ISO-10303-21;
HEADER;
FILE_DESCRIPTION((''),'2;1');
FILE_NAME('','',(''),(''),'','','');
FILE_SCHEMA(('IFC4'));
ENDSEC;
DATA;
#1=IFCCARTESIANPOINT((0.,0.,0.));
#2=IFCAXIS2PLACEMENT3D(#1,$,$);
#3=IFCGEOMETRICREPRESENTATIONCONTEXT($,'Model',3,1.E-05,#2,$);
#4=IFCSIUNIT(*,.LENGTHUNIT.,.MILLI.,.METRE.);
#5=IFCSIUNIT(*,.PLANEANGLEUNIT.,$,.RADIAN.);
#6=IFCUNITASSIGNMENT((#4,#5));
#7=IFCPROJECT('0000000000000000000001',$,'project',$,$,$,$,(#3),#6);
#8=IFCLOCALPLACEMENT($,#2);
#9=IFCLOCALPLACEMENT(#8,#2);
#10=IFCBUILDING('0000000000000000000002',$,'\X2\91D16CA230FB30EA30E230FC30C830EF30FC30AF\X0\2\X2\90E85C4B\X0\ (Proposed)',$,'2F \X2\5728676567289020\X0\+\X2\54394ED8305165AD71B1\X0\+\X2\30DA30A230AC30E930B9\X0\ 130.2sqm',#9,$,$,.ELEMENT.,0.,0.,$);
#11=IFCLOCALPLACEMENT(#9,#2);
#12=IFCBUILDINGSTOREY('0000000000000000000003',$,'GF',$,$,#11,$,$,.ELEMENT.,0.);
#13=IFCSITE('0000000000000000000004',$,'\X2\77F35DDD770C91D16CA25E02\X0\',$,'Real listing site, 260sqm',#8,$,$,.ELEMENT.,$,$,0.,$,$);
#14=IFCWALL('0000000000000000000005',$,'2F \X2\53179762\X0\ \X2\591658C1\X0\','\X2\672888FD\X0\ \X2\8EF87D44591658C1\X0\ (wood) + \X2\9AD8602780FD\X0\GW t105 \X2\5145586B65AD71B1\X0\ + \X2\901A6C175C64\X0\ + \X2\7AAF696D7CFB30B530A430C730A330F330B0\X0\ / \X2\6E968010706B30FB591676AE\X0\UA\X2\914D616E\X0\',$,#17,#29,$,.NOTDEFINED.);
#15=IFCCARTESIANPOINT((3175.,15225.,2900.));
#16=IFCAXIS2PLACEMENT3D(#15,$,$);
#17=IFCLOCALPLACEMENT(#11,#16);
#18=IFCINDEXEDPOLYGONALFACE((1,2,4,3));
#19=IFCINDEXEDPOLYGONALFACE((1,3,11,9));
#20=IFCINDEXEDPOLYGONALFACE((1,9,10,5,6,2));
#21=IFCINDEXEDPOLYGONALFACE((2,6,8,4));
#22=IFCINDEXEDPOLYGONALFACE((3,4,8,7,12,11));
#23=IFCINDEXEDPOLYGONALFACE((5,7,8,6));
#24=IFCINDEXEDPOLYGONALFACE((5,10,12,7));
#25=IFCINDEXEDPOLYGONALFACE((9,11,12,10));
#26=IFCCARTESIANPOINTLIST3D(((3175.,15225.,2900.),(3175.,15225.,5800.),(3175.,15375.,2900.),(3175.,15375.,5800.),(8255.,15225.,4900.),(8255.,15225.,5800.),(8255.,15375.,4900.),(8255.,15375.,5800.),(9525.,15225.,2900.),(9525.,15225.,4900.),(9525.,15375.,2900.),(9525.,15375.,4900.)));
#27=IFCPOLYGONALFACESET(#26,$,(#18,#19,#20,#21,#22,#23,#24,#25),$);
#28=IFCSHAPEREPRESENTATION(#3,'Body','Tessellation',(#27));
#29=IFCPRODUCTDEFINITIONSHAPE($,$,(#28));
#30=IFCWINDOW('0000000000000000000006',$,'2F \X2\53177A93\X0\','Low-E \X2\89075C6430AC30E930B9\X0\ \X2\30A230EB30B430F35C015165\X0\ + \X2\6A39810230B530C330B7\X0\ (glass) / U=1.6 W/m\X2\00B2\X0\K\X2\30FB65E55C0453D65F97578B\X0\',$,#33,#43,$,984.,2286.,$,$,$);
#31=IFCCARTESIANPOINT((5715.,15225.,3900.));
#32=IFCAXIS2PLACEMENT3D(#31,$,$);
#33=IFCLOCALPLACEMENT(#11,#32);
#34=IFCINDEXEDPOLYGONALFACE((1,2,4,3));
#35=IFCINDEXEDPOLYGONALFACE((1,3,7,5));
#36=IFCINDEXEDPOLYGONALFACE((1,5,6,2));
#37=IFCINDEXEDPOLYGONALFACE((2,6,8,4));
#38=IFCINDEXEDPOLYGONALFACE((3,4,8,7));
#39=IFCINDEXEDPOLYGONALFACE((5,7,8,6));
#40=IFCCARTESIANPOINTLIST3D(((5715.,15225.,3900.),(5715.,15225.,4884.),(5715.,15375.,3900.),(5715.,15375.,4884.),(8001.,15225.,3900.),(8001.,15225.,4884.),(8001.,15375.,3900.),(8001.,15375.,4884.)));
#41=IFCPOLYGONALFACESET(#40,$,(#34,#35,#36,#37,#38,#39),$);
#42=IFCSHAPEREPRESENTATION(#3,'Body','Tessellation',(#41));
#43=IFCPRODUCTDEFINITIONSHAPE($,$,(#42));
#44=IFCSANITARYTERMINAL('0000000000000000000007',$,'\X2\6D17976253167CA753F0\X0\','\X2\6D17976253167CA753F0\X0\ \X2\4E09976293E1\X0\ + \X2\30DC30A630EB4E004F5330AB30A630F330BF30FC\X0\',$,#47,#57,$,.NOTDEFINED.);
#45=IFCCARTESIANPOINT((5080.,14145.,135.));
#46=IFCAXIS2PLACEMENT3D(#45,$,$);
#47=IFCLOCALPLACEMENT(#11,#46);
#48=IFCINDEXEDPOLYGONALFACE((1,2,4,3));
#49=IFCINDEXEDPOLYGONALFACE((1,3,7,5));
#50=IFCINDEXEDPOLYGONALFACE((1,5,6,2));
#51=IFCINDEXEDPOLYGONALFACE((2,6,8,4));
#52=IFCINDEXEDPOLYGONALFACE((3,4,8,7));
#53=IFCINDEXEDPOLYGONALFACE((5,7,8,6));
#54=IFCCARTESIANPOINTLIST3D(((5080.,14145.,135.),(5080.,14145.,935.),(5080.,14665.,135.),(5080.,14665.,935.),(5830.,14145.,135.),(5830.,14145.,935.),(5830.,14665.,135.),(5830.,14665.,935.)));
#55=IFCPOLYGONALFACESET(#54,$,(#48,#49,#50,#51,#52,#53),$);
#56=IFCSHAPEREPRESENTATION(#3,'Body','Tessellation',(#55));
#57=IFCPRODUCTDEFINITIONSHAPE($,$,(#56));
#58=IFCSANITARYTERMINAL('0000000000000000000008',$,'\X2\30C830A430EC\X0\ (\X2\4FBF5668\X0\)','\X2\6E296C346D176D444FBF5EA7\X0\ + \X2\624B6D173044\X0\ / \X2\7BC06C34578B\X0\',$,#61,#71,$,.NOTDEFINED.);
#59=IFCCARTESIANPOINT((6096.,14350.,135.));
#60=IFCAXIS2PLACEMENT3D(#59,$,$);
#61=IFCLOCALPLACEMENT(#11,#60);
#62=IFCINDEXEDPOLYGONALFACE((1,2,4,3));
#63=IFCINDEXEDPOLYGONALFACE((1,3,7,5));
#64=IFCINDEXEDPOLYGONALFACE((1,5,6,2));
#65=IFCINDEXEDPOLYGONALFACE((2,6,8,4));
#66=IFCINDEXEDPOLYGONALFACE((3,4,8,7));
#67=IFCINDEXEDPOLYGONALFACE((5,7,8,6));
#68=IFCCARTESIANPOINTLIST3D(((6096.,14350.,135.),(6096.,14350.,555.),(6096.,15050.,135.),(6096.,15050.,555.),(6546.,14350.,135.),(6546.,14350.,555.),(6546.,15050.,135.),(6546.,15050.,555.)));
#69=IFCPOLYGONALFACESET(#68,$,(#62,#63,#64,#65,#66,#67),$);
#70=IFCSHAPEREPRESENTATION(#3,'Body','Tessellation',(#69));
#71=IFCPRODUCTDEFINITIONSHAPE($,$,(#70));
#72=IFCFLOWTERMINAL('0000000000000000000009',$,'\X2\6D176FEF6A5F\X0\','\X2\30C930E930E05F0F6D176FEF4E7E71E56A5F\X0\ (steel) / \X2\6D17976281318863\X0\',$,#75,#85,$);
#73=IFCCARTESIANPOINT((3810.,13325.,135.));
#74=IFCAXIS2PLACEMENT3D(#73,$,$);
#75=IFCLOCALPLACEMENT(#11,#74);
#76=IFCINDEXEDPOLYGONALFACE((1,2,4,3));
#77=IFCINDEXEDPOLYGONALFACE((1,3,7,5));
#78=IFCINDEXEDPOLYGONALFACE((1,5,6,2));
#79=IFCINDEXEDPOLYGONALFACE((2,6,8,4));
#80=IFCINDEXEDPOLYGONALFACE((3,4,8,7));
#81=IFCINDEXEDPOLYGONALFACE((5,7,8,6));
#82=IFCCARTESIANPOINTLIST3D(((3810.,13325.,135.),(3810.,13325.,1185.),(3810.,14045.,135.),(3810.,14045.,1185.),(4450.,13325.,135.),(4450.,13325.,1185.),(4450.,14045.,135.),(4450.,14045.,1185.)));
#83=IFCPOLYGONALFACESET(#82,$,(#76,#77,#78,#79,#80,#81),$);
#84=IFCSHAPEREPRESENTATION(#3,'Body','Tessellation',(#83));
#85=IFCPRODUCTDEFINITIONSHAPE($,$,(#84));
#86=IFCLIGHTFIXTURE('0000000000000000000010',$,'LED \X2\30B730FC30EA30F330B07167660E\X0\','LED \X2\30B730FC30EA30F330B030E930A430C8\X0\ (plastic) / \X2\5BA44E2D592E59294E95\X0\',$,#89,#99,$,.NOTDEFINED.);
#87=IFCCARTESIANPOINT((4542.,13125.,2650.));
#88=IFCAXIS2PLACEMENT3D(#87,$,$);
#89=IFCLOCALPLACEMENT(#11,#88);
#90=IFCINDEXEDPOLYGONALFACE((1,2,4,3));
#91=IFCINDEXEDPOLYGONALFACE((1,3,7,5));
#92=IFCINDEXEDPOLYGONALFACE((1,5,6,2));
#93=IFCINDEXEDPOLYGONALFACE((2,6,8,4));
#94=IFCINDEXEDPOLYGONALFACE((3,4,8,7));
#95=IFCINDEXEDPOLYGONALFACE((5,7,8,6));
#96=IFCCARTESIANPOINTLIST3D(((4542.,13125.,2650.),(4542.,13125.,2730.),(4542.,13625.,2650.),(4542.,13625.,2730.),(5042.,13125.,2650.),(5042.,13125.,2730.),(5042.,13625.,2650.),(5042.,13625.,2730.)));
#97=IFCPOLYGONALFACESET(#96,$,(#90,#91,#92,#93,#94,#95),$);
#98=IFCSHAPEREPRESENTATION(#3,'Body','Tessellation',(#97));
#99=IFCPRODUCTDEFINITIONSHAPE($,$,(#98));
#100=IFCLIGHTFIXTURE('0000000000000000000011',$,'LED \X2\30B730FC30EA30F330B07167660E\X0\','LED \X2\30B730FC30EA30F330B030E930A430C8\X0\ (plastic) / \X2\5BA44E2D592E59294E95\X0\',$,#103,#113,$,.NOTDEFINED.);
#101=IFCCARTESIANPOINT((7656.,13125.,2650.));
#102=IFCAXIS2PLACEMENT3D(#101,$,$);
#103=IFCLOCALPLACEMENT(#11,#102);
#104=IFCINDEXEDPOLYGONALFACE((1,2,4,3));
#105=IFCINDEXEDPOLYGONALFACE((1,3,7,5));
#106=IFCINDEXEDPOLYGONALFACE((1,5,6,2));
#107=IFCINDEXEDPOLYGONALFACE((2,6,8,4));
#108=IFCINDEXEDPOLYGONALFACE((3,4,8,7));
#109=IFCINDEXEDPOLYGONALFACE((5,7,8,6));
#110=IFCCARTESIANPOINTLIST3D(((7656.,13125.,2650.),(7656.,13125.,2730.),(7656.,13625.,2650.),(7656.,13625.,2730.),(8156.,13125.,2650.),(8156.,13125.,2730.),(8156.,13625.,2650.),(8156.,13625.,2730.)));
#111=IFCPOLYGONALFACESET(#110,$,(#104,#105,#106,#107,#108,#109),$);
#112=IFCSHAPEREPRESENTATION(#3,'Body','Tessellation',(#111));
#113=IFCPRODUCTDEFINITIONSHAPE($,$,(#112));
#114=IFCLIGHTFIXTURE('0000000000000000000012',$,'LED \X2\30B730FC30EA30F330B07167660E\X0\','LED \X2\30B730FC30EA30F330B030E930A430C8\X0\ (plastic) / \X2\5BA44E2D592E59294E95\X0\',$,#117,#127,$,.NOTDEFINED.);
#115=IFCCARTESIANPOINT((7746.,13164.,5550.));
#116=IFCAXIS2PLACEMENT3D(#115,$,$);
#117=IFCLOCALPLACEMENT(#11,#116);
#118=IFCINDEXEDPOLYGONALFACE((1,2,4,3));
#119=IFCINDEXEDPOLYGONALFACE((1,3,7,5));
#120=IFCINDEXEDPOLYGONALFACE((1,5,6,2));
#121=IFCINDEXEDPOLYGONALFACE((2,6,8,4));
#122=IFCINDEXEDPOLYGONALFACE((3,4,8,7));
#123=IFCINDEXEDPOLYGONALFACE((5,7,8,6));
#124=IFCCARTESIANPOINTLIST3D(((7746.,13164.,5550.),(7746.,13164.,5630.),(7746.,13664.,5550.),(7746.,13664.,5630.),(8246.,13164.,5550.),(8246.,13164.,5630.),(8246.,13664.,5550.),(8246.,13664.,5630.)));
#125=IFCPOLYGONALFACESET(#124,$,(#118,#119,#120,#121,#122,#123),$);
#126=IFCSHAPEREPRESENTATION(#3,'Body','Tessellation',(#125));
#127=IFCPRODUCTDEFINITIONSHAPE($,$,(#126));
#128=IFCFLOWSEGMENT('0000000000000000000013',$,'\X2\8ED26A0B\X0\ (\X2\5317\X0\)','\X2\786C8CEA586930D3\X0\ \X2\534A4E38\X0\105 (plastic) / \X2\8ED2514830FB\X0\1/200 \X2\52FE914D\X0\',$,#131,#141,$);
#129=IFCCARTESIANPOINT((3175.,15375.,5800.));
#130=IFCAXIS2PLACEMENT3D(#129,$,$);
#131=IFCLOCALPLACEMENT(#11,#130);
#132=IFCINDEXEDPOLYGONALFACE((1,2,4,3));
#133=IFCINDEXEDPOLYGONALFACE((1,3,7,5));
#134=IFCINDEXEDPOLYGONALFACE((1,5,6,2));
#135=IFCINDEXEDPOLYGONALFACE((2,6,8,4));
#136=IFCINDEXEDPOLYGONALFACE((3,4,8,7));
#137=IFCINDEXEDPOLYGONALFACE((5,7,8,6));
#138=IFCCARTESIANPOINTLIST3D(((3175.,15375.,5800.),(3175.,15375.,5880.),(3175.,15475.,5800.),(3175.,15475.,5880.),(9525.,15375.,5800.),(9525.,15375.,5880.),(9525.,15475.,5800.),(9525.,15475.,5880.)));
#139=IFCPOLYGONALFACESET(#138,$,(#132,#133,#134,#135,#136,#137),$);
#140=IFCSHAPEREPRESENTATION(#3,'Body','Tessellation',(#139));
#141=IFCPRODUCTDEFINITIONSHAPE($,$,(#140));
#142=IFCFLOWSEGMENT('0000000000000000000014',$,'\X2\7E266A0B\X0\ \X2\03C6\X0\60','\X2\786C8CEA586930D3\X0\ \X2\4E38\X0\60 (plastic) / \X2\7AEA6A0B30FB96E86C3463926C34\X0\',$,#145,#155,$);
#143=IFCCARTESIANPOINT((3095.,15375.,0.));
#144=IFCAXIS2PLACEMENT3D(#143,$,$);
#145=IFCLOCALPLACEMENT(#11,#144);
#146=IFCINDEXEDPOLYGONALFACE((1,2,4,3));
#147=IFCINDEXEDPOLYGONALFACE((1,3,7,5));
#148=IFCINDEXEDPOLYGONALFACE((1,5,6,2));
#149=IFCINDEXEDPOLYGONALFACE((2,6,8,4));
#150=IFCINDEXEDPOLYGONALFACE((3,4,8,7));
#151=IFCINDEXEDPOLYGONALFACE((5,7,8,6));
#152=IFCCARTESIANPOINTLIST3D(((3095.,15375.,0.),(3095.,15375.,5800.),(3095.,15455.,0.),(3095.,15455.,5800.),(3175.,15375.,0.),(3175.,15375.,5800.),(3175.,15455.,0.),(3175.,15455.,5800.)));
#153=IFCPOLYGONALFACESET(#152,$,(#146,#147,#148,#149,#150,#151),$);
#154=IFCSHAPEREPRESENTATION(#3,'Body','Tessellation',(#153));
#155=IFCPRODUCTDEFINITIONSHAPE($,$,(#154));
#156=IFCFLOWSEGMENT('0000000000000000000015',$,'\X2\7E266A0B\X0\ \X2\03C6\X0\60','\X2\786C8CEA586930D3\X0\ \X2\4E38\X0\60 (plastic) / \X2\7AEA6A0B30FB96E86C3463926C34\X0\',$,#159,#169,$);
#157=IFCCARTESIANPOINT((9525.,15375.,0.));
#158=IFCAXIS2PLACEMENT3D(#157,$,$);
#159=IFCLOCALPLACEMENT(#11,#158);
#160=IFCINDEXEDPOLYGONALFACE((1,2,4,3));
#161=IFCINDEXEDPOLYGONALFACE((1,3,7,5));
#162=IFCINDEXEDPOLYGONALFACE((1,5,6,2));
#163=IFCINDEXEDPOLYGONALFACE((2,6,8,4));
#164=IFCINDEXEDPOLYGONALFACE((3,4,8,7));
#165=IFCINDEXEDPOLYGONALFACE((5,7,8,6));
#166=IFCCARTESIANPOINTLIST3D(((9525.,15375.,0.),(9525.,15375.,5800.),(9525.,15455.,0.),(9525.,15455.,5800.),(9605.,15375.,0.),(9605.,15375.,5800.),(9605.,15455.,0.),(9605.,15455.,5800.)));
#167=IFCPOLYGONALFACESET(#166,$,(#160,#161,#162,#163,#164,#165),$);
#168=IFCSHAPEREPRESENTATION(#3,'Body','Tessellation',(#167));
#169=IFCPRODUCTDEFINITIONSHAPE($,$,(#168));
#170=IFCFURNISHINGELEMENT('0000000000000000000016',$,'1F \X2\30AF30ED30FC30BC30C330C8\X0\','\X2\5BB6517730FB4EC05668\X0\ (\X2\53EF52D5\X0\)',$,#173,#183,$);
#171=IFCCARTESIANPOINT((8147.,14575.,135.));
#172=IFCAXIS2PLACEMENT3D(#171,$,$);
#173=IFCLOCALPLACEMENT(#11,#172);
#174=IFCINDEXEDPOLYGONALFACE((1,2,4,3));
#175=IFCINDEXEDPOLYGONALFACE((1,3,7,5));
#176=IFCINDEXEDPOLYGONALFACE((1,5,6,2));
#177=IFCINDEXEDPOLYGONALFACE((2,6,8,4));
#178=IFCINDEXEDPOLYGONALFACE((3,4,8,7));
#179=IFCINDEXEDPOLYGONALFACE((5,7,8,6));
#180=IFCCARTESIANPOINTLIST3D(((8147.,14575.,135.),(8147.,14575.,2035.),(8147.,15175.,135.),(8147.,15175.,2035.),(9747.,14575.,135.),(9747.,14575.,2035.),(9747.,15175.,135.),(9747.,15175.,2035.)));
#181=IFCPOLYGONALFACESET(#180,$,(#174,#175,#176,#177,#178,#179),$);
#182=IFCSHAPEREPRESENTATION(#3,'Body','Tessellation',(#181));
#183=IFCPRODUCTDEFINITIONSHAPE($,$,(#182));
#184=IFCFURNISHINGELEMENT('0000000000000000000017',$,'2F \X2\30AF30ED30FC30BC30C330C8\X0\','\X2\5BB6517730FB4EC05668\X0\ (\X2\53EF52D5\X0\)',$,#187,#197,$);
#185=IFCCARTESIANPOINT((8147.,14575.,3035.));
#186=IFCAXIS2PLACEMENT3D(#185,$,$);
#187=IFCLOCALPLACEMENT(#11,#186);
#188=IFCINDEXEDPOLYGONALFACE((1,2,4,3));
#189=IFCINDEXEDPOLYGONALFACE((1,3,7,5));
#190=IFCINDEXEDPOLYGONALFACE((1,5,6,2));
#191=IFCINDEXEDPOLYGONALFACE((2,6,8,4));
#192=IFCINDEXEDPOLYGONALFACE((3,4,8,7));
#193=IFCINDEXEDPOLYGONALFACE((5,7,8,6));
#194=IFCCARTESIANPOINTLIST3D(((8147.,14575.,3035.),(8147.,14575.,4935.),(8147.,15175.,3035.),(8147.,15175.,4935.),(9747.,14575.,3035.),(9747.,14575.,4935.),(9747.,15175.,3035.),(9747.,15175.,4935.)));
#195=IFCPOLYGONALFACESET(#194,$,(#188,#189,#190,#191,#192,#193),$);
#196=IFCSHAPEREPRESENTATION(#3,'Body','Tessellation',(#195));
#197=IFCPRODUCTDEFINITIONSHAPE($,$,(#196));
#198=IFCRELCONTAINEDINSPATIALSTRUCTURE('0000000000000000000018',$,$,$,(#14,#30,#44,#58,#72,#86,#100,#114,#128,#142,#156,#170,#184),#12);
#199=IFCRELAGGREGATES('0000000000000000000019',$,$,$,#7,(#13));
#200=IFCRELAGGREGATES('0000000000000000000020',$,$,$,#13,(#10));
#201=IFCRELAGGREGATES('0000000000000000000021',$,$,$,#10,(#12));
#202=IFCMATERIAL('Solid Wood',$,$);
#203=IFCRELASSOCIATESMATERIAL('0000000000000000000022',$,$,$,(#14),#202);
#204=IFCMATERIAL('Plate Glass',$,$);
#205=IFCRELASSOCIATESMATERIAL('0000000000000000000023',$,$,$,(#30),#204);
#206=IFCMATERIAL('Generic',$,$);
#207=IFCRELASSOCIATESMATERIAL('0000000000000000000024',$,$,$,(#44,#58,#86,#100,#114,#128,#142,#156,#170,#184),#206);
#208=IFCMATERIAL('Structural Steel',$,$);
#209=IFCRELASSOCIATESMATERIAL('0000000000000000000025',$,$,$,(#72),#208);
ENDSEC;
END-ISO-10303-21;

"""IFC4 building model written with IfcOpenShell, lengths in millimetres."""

from ifc_helpers import new_model, si_unit, frame, frame_2d, origin, place, context, project, spatial, rectangle, extrude, material, element, fill, save


model = new_model("IFC4")

# Units and contexts
model_context = context("Model", 3, precision=1e-05, world=origin())
ifc_project = project(units=[si_unit("LENGTHUNIT", "METRE", prefix="MILLI"), si_unit("PLANEANGLEUNIT", "RADIAN")], contexts=[model_context])

# Site, building, storey
site_placement = place(None, origin())
site = spatial("IfcSite", under=ifc_project, at=site_placement, Name="石川県金沢市", ObjectType="Real listing site, 260sqm", CompositionType="ELEMENT", RefElevation=0.0)
building_placement = place(site_placement, origin())
building = spatial("IfcBuilding", under=site, at=building_placement, Name="金沢・リモートワーク2部屋 (Proposed)", ObjectType="2F 在来木造+吹付け断熱+ペアガラス 130.2sqm", CompositionType="ELEMENT", ElevationOfRefHeight=0.0, ElevationOfTerrain=0.0)
storey_placement = place(building_placement, origin())
storey = spatial("IfcBuildingStorey", under=building, at=storey_placement, Name="GF", CompositionType="ELEMENT", Elevation=0.0)

# Shared definitions
ifc_material_1 = material(Name="Solid Wood")

# Shared definitions
ifc_material_2 = material(Name="Plate Glass")

# Wall, opening, window
wall_1_placement = place(storey_placement, frame((3175.0, 15225.0, 2900.0)))
wall_1 = element("IfcWall", 1, at=wall_1_placement, inside=storey, material=ifc_material_1, Name="2F 北面 外壁", Description="木製 軸組外壁 (wood) + 高性能GW t105 充填断熱 + 通気層 + 窯業系サイディング / 準耐火・外皮UA配慮", PredefinedType="NOTDEFINED", context=model_context, shape_type="SweptSolid", body=[
    extrude(rectangle(XDim=6350.0, YDim=150.0, at=frame_2d((3175.0, 75.0))), frame((3175.0, 15225.0, 2900.0)), (0.0, 0.0, 1.0), 2900.0),
])
opening_1_placement = place(storey_placement, frame((5715.0, 15225.0, 3900.0)))
opening_1 = element("IfcOpeningElement", 2, at=opening_1_placement, cuts=wall_1, PredefinedType="NOTDEFINED", context=model_context, shape_type="SweptSolid", body=[
    extrude(rectangle(XDim=2286.0, YDim=150.0, at=frame_2d((1143.0, 75.0))), frame((5715.0, 15225.0, 3900.0)), (0.0, 0.0, 1.0), 984.0),
])
window_1_placement = place(storey_placement, frame((5715.0, 15225.0, 3900.0)))
window_1 = element("IfcWindow", 3, at=window_1_placement, inside=storey, material=ifc_material_2, Name="2F 北窓", Description="Low-E 複層ガラス アルゴン封入 + 樹脂サッシ (glass) / U=1.6 W/m²K・日射取得型", OverallHeight=984.0, OverallWidth=2286.0, context=model_context, shape_type="SweptSolid", body=[
    extrude(rectangle(XDim=2286.0, YDim=150.0, at=frame_2d((1143.0, 75.0))), frame((5715.0, 15225.0, 3900.0)), (0.0, 0.0, 1.0), 984.0),
])
fill(opening_1, window_1)

# Sanitary terminals
ifc_material_3 = material(Name="Generic")
sanitary_terminal_1_placement = place(storey_placement, frame((5080.0, 14145.0, 135.0)))
element("IfcSanitaryTerminal", 4, at=sanitary_terminal_1_placement, inside=storey, material=ifc_material_3, Name="洗面化粧台", Description="洗面化粧台 三面鏡 + ボウル一体カウンター", PredefinedType="NOTDEFINED", context=model_context, shape_type="SweptSolid", body=[
    extrude(rectangle(XDim=750.0, YDim=520.0, at=frame_2d((375.0, 260.0))), frame((5080.0, 14145.0, 135.0)), (0.0, 0.0, 1.0), 800.0),
])
sanitary_terminal_2_placement = place(storey_placement, frame((6096.0, 14350.0, 135.0)))
element("IfcSanitaryTerminal", 5, at=sanitary_terminal_2_placement, inside=storey, material=ifc_material_3, Name="トイレ (便器)", Description="温水洗浄便座 + 手洗い / 節水型", PredefinedType="NOTDEFINED", context=model_context, shape_type="SweptSolid", body=[
    extrude(rectangle(XDim=450.0, YDim=700.0, at=frame_2d((225.0, 350.0))), frame((6096.0, 14350.0, 135.0)), (0.0, 0.0, 1.0), 420.0),
])

# Flow terminal
ifc_material_4 = material(Name="Structural Steel")
flow_terminal_placement = place(storey_placement, frame((3810.0, 13325.0, 135.0)))
element("IfcFlowTerminal", 6, at=flow_terminal_placement, inside=storey, material=ifc_material_4, Name="洗濯機", Description="ドラム式洗濯乾燥機 (steel) / 洗面脱衣", context=model_context, shape_type="SweptSolid", body=[
    extrude(rectangle(XDim=640.0, YDim=720.0, at=frame_2d((320.0, 360.0))), frame((3810.0, 13325.0, 135.0)), (0.0, 0.0, 1.0), 1050.0),
])

# Light fixtures
light_fixture_1_placement = place(storey_placement, frame((4542.0, 13125.0, 2650.0)))
element("IfcLightFixture", 7, at=light_fixture_1_placement, inside=storey, material=ifc_material_3, Name="LED シーリング照明", Description="LED シーリングライト (plastic) / 室中央天井", PredefinedType="NOTDEFINED", context=model_context, shape_type="SweptSolid", body=[
    extrude(rectangle(XDim=500.0, YDim=500.0, at=frame_2d((250.0, 250.0))), frame((4542.0, 13125.0, 2650.0)), (0.0, 0.0, 1.0), 80.0),
])
light_fixture_2_placement = place(storey_placement, frame((7656.0, 13125.0, 2650.0)))
element("IfcLightFixture", 8, at=light_fixture_2_placement, inside=storey, material=ifc_material_3, Name="LED シーリング照明", Description="LED シーリングライト (plastic) / 室中央天井", PredefinedType="NOTDEFINED", context=model_context, shape_type="SweptSolid", body=[
    extrude(rectangle(XDim=500.0, YDim=500.0, at=frame_2d((250.0, 250.0))), frame((7656.0, 13125.0, 2650.0)), (0.0, 0.0, 1.0), 80.0),
])
light_fixture_3_placement = place(storey_placement, frame((7746.0, 13164.0, 5550.0)))
element("IfcLightFixture", 9, at=light_fixture_3_placement, inside=storey, material=ifc_material_3, Name="LED シーリング照明", Description="LED シーリングライト (plastic) / 室中央天井", PredefinedType="NOTDEFINED", context=model_context, shape_type="SweptSolid", body=[
    extrude(rectangle(XDim=500.0, YDim=500.0, at=frame_2d((250.0, 250.0))), frame((7746.0, 13164.0, 5550.0)), (0.0, 0.0, 1.0), 80.0),
])

# Flow segments
flow_segment_1_placement = place(storey_placement, frame((3175.0, 15375.0, 5800.0)))
element("IfcFlowSegment", 10, at=flow_segment_1_placement, inside=storey, material=ifc_material_3, Name="軒樋 (北)", Description="硬質塩ビ 半丸105 (plastic) / 軒先・1/200 勾配", context=model_context, shape_type="SweptSolid", body=[
    extrude(rectangle(XDim=6350.0, YDim=100.0, at=frame_2d((3175.0, 50.0))), frame((3175.0, 15375.0, 5800.0)), (0.0, 0.0, 1.0), 80.0),
])
flow_segment_2_placement = place(storey_placement, frame((3095.0, 15375.0, 0.0)))
element("IfcFlowSegment", 11, at=flow_segment_2_placement, inside=storey, material=ifc_material_3, Name="縦樋 φ60", Description="硬質塩ビ 丸60 (plastic) / 竪樋・雨水排水", context=model_context, shape_type="SweptSolid", body=[
    extrude(rectangle(XDim=80.0, YDim=80.0, at=frame_2d((40.0, 40.0))), frame((3095.0, 15375.0, 0.0)), (0.0, 0.0, 1.0), 5800.0),
])
flow_segment_3_placement = place(storey_placement, frame((9525.0, 15375.0, 0.0)))
element("IfcFlowSegment", 12, at=flow_segment_3_placement, inside=storey, material=ifc_material_3, Name="縦樋 φ60", Description="硬質塩ビ 丸60 (plastic) / 竪樋・雨水排水", context=model_context, shape_type="SweptSolid", body=[
    extrude(rectangle(XDim=80.0, YDim=80.0, at=frame_2d((40.0, 40.0))), frame((9525.0, 15375.0, 0.0)), (0.0, 0.0, 1.0), 5800.0),
])

# Furnishing elements
furnishing_1_placement = place(storey_placement, frame((8147.0, 14575.0, 135.0)))
element("IfcFurnishingElement", 13, at=furnishing_1_placement, inside=storey, material=ifc_material_3, Name="1F クローゼット", Description="家具・什器 (可動)", context=model_context, shape_type="SweptSolid", body=[
    extrude(rectangle(XDim=1600.0, YDim=600.0, at=frame_2d((800.0, 300.0))), frame((8147.0, 14575.0, 135.0)), (0.0, 0.0, 1.0), 1900.0),
])
furnishing_2_placement = place(storey_placement, frame((8147.0, 14575.0, 3035.0)))
element("IfcFurnishingElement", 14, at=furnishing_2_placement, inside=storey, material=ifc_material_3, Name="2F クローゼット", Description="家具・什器 (可動)", context=model_context, shape_type="SweptSolid", body=[
    extrude(rectangle(XDim=1600.0, YDim=600.0, at=frame_2d((800.0, 300.0))), frame((8147.0, 14575.0, 3035.0)), (0.0, 0.0, 1.0), 1900.0),
])

save(model, "model.ifc")
